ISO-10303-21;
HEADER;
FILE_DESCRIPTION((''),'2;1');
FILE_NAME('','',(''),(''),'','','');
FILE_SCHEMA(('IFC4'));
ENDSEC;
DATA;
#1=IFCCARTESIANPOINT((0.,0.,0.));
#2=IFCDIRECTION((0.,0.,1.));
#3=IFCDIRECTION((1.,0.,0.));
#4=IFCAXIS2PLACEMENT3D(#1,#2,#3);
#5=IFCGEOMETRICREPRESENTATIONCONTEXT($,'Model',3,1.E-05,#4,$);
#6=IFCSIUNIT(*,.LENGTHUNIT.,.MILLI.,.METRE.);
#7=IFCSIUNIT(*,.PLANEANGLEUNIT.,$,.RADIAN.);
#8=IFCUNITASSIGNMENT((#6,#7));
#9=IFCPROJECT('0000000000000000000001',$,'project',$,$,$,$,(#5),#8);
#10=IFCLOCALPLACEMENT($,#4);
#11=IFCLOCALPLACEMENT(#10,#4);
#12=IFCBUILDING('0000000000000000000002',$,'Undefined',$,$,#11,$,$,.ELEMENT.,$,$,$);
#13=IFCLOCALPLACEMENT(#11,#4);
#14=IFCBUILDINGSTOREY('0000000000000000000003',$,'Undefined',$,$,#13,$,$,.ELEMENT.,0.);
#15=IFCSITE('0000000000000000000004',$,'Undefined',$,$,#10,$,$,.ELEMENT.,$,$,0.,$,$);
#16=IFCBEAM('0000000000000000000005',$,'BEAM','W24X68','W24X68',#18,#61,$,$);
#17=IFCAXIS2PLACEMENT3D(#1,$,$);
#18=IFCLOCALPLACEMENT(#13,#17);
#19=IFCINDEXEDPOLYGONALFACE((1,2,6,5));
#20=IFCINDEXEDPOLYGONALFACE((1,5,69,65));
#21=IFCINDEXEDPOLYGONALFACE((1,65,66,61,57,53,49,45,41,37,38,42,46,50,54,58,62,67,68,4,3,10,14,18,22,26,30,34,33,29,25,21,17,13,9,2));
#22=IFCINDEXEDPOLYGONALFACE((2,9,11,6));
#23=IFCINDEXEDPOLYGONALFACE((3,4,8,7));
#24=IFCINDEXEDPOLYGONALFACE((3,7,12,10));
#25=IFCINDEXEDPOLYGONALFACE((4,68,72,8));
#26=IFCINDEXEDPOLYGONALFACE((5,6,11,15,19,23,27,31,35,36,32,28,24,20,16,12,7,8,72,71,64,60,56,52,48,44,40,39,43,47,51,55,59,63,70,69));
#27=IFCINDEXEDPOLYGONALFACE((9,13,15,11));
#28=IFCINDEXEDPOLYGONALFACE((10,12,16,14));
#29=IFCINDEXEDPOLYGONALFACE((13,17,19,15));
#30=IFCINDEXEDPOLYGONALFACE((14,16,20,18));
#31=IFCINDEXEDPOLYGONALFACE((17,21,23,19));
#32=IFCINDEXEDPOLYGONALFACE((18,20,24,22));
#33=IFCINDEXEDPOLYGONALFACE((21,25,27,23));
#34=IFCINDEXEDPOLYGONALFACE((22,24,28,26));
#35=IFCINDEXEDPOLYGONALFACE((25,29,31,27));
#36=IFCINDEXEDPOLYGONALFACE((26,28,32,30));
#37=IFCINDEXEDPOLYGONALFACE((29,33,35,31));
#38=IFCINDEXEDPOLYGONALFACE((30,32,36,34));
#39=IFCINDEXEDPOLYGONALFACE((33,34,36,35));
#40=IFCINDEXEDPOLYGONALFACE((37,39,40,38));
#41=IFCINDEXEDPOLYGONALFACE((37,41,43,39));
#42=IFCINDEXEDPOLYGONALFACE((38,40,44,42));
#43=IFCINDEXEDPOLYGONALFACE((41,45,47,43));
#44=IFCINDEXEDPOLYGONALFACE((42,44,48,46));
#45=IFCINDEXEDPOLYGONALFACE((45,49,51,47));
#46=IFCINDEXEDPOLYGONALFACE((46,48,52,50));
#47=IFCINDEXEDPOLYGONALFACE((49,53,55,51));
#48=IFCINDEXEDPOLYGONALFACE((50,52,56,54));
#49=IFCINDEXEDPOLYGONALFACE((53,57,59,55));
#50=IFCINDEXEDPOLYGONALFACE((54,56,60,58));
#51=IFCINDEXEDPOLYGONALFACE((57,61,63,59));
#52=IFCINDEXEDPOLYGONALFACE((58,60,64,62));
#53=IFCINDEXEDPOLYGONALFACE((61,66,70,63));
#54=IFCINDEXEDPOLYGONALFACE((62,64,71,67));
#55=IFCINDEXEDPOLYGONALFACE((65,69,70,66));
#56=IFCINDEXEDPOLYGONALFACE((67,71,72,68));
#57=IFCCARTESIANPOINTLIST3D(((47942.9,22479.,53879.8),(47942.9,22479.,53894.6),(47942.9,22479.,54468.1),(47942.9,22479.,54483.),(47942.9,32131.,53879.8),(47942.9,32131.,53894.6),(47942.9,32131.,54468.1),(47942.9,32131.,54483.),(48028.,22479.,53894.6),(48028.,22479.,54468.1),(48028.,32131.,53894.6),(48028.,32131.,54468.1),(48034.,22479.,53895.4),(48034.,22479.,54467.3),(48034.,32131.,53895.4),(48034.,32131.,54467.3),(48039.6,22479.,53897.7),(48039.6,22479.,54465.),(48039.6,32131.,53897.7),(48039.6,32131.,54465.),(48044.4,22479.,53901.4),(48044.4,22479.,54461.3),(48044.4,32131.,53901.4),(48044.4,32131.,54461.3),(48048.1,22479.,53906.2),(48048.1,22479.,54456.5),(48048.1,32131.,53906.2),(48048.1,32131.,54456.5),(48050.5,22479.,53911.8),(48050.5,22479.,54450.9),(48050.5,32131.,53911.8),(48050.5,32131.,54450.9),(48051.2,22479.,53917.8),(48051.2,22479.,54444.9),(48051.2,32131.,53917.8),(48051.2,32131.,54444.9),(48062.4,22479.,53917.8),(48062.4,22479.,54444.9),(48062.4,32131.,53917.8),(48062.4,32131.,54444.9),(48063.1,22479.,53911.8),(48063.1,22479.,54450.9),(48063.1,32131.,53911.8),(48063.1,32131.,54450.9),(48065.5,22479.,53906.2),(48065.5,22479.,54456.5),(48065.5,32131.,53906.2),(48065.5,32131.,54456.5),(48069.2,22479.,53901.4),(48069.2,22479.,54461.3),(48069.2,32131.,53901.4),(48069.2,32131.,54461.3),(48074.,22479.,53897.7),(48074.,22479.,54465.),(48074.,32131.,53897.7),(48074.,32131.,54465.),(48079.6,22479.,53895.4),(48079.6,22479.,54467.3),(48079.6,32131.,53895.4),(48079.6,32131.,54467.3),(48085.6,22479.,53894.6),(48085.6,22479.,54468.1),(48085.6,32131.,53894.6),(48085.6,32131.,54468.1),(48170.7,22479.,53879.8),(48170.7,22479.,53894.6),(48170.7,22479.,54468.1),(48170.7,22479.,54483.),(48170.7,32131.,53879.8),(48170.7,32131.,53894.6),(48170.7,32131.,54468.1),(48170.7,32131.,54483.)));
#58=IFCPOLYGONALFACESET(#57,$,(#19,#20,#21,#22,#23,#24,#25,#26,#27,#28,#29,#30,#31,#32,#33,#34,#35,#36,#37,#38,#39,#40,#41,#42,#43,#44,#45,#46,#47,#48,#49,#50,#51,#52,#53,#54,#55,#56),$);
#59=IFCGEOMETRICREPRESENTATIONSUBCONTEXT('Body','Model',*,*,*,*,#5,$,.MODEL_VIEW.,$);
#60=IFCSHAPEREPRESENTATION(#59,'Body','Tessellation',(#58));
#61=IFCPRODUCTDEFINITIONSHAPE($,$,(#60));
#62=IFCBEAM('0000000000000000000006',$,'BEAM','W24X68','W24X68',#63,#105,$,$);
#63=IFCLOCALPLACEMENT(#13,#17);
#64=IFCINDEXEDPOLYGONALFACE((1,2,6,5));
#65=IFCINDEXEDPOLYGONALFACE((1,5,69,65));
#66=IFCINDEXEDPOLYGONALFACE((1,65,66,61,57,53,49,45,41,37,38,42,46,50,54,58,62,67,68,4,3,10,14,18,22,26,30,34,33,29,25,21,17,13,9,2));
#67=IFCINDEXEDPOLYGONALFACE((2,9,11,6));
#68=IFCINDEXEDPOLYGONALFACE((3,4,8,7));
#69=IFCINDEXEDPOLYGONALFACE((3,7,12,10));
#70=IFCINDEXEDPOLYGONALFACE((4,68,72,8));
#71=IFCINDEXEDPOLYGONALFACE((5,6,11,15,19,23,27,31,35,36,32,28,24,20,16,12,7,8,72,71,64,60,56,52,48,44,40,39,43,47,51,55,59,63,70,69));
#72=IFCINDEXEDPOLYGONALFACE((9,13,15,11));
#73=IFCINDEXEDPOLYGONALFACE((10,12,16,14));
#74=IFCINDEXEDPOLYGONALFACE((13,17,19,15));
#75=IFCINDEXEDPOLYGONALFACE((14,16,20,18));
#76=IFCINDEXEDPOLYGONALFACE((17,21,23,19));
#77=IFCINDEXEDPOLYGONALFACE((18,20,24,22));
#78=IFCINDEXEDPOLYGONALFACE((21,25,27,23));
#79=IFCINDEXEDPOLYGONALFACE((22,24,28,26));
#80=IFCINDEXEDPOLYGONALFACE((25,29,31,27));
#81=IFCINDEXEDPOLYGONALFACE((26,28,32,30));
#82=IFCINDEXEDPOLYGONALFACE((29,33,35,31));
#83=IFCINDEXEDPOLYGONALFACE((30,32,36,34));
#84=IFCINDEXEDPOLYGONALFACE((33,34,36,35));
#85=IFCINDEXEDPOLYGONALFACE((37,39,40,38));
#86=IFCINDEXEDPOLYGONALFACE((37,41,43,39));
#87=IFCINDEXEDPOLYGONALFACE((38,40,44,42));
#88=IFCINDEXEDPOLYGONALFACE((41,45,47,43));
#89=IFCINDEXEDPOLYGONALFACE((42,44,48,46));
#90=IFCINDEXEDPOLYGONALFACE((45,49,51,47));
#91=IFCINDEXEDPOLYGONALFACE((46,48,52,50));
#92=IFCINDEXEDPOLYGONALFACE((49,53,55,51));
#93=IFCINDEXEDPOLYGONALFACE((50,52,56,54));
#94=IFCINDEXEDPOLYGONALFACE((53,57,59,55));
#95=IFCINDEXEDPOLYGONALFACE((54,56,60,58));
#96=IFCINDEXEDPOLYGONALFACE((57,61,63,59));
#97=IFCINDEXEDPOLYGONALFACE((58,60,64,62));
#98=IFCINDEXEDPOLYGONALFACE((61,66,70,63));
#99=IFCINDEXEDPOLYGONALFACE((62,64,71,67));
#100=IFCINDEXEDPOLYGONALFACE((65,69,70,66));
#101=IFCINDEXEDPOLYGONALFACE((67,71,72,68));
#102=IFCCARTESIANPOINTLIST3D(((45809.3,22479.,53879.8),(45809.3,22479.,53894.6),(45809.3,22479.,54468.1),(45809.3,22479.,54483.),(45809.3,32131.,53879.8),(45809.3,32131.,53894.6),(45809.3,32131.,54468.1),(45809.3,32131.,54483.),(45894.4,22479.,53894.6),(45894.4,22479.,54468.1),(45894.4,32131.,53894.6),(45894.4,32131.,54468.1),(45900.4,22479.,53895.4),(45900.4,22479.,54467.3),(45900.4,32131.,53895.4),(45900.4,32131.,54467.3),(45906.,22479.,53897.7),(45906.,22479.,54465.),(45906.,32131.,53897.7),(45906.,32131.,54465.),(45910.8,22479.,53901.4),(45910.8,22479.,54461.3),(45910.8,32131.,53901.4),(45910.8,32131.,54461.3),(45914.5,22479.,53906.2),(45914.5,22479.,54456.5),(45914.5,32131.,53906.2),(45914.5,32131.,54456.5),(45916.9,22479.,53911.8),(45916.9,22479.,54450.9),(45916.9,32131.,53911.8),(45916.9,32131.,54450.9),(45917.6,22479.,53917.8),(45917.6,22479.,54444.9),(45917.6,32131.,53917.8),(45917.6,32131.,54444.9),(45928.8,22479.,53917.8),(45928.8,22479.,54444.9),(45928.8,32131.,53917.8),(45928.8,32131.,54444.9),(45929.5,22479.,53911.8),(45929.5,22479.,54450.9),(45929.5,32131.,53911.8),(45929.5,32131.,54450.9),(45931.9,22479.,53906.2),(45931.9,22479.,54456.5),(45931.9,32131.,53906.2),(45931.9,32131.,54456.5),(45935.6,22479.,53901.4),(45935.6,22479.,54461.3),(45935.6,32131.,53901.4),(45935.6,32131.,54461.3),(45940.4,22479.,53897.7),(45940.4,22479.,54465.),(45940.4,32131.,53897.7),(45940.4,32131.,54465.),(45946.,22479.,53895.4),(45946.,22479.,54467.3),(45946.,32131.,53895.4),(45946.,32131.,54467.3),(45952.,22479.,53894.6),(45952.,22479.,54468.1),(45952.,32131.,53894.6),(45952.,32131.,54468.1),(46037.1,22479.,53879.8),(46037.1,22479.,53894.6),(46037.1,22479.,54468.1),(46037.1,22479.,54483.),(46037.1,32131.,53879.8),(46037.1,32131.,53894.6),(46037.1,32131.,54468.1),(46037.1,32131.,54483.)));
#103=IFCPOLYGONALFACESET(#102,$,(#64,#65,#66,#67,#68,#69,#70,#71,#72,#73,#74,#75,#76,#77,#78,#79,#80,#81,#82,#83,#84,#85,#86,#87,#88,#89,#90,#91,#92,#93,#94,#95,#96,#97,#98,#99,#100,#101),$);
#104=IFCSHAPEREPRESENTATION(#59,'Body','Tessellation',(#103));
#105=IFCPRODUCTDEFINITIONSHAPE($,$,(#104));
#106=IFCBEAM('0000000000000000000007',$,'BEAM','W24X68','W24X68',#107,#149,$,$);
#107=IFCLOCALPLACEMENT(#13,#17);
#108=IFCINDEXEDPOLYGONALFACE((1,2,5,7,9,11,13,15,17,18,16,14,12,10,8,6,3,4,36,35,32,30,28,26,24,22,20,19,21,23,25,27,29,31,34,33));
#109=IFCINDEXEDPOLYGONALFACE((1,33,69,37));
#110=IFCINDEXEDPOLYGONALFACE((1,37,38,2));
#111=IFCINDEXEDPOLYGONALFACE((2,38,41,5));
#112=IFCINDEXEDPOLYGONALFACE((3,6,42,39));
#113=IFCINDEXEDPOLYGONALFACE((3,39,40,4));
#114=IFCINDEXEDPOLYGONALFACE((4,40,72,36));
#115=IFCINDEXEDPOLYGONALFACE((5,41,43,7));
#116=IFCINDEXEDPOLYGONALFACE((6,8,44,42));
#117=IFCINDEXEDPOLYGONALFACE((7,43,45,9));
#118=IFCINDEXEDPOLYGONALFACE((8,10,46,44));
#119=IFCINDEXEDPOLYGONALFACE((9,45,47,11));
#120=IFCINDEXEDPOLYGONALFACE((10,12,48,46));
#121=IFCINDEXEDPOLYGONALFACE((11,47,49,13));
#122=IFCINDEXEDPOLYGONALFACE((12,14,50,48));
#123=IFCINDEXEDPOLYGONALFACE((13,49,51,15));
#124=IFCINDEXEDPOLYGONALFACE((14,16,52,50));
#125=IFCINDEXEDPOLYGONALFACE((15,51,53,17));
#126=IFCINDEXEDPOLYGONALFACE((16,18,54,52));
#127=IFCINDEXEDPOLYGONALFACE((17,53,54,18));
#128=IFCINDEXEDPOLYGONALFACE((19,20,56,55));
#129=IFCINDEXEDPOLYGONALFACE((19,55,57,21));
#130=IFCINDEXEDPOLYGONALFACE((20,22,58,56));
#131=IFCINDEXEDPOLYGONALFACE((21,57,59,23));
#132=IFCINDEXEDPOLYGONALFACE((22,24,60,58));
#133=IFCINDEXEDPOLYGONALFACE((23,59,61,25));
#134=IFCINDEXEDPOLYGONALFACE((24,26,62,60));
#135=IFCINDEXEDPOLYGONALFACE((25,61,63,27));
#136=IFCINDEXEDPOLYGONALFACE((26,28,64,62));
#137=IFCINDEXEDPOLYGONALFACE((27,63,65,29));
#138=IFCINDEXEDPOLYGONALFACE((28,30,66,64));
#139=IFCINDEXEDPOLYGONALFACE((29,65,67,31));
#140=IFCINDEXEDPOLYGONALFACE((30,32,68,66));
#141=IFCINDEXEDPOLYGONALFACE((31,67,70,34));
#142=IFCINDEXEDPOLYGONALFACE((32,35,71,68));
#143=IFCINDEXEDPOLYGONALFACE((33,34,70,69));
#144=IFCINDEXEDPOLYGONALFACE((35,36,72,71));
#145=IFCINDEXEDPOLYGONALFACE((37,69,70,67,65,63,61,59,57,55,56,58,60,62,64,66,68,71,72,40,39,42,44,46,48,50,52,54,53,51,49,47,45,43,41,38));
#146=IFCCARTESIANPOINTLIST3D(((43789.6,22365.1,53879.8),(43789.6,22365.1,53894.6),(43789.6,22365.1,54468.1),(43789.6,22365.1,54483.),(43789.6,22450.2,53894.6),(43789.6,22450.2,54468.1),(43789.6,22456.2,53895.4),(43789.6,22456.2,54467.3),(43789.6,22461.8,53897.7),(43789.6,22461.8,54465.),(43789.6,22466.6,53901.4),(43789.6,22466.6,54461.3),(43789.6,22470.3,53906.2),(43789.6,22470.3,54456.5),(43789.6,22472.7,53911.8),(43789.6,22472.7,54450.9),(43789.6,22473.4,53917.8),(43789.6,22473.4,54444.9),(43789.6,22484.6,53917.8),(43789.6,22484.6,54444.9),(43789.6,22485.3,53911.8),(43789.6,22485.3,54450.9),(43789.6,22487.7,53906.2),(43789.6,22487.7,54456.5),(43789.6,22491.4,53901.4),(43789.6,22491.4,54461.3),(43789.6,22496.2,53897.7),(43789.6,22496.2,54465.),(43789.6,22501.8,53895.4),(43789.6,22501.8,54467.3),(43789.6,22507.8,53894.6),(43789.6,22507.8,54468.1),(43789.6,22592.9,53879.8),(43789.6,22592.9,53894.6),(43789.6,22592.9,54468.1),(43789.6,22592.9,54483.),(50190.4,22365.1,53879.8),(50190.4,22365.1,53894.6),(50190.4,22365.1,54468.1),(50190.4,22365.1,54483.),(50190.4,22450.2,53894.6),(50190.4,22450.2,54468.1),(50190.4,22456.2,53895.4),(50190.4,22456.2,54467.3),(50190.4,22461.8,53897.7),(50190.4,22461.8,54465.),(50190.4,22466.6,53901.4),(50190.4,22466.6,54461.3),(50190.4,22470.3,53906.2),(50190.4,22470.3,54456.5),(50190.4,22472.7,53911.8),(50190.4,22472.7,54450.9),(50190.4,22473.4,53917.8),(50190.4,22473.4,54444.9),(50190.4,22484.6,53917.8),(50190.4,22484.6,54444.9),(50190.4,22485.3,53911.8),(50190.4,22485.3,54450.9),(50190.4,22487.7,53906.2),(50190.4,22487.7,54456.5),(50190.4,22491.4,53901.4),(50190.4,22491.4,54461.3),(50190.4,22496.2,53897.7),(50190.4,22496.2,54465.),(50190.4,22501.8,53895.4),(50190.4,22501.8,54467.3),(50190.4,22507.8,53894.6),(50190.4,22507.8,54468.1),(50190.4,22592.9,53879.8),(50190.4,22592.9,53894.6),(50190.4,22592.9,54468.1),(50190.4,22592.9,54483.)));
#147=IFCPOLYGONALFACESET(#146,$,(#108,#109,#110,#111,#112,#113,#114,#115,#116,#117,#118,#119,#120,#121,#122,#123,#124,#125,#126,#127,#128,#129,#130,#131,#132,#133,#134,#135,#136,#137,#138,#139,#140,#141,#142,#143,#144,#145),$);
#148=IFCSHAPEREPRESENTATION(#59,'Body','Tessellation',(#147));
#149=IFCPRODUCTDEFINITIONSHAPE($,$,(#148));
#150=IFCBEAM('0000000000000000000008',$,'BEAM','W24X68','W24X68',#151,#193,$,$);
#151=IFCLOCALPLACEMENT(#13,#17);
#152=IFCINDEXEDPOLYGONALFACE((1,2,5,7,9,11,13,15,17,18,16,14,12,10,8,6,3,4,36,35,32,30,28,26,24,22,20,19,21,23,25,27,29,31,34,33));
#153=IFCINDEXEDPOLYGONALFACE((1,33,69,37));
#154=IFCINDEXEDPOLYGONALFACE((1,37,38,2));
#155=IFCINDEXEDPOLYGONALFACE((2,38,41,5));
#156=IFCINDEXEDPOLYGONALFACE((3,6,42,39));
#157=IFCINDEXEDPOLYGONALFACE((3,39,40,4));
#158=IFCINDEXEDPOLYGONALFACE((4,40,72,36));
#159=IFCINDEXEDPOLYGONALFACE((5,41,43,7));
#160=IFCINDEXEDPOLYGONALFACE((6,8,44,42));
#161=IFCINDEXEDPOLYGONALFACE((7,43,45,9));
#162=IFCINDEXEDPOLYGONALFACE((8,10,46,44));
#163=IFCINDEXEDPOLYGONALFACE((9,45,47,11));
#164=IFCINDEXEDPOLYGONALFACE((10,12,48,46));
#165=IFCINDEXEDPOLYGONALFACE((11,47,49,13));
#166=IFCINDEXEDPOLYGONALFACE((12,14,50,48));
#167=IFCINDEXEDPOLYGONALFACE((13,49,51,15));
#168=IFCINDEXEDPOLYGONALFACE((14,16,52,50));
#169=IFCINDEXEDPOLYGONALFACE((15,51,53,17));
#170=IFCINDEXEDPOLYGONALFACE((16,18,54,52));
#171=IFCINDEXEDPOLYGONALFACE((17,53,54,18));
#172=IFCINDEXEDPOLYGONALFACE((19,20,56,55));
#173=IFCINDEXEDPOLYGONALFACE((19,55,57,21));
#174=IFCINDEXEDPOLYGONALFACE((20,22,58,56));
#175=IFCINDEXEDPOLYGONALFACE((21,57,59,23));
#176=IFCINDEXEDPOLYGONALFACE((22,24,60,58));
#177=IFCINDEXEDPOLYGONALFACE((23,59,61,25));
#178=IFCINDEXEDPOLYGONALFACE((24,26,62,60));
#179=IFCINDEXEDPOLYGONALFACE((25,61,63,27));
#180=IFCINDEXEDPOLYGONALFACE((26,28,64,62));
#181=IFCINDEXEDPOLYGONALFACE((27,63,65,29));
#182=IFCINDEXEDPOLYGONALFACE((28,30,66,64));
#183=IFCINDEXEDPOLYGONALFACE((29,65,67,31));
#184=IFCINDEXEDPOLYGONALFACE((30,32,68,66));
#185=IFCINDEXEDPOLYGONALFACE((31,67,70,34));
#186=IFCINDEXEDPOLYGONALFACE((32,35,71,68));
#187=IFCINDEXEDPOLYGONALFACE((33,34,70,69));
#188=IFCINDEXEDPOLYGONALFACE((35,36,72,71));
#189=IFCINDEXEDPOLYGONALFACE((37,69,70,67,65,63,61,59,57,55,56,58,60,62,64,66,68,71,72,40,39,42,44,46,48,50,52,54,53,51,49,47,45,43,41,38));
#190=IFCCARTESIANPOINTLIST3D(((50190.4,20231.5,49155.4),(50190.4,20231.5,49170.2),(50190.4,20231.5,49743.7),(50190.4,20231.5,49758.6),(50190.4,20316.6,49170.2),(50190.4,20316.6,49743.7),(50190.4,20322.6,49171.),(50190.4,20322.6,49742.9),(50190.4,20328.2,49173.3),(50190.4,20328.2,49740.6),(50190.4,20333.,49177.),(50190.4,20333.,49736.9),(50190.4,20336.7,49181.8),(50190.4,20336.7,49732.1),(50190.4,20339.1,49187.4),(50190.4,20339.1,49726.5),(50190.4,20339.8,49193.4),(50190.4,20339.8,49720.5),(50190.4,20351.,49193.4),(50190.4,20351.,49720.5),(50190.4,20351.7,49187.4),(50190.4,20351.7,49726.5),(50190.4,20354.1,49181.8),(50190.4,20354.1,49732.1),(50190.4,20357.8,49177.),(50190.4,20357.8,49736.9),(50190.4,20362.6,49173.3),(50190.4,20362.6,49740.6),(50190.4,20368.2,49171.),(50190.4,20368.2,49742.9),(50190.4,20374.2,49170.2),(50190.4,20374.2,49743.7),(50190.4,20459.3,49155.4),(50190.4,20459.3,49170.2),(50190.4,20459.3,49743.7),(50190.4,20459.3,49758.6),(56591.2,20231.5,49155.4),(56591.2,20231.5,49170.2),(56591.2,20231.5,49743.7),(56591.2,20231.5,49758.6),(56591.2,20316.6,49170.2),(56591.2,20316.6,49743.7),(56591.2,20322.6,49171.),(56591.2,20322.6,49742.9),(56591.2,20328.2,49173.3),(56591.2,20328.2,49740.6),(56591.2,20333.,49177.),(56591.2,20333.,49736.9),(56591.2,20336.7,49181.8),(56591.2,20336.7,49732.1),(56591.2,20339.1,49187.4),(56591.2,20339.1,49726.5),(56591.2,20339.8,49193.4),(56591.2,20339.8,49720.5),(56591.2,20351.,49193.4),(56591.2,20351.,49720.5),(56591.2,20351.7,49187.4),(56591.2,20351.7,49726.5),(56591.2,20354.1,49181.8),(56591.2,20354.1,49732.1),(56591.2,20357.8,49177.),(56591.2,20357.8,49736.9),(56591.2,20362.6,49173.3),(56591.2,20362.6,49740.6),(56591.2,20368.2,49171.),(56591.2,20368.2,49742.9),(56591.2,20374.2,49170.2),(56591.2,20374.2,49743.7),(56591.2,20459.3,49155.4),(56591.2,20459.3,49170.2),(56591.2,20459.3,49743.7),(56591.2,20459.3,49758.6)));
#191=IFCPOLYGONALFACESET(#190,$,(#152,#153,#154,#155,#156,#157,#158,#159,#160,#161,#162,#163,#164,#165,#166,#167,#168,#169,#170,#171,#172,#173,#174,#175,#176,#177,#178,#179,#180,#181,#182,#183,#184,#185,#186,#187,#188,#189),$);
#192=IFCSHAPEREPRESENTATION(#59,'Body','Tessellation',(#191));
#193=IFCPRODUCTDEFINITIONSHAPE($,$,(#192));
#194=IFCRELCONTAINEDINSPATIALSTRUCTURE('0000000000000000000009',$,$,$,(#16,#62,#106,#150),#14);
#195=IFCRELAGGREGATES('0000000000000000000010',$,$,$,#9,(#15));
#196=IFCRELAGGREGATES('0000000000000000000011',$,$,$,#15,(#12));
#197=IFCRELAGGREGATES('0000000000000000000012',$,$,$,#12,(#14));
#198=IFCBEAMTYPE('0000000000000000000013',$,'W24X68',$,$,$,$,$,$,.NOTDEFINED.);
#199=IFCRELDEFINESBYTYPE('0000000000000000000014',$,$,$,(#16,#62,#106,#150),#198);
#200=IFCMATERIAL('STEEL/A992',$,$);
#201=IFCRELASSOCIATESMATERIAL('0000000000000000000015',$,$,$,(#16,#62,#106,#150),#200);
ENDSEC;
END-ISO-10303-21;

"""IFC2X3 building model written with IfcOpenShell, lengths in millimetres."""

from ifc_helpers import new_model, si_unit, frame, origin_with_axes, origin_2d_with_axis, place, context, subcontext, project, spatial, i_section, extrude, material, type_object, element, save


model = new_model("IFC2X3")

# Units and contexts
model_context = context("Model", 3, precision=1e-05, world=origin_with_axes())
body_context = subcontext(model_context, "Body", "Model", "MODEL_VIEW")
ifc_project = project(units=[si_unit("LENGTHUNIT", "METRE", prefix="MILLI"), si_unit("PLANEANGLEUNIT", "RADIAN")], contexts=[model_context])

# Site, building, storey
site_placement = place(None, origin_with_axes())
site = spatial("IfcSite", under=ifc_project, at=site_placement, Name="Undefined", CompositionType="ELEMENT", RefElevation=0.0)
building_placement = place(site_placement, origin_with_axes())
building = spatial("IfcBuilding", under=site, at=building_placement, Name="Undefined", CompositionType="ELEMENT")
storey_placement = place(building_placement, origin_with_axes())
storey = spatial("IfcBuildingStorey", under=building, at=storey_placement, Name="Undefined", CompositionType="ELEMENT", Elevation=0.0)

# Shared definitions
ifc_material = material(Name="STEEL/A992")

# Beams
beam_type = type_object("IfcBeamType", Name="W24X68", PredefinedType="NOTDEFINED")
for number, where, z_axis, x_axis, name in (
    (1, (48056.8, 22479.0, 54181.4), (0.0, 0.0, 1.0), (0.0, 1.0, 0.0), "BEAM"),
    (2, (45923.2, 22479.0, 54181.4), (0.0, 0.0, 1.0), (0.0, 1.0, 0.0), "BEAM"),
):
    element("IfcBeam", number, at=place(storey_placement, frame(where, z_axis=z_axis, x_axis=x_axis)), inside=storey, type_object=beam_type, material=ifc_material, Name=name, Description="W24X68", ObjectType="W24X68", context=body_context, shape_type="SweptSolid", body=[
        extrude(i_section(OverallWidth=227.8, OverallDepth=603.2, WebThickness=11.1, FlangeThickness=14.9, FilletRadius=23.2, at=origin_2d_with_axis()), frame((9652.0, 0.0, 0.0), z_axis=(-1.0, 0.0, 0.0), x_axis=(0.0, -1.0, 0.0)), (0.0, 0.0, 1.0), 9652.0),
    ])
beam_1_placement = place(storey_placement, frame((43789.6, 22479.0, 54181.4), z_axis=(0.0, 0.0, 1.0), x_axis=(1.0, 0.0, 0.0)))
element("IfcBeam", 3, at=beam_1_placement, inside=storey, type_object=beam_type, material=ifc_material, Name="BEAM", Description="W24X68", ObjectType="W24X68", context=body_context, shape_type="SweptSolid", body=[
    extrude(i_section(OverallWidth=227.8, OverallDepth=603.2, WebThickness=11.1, FlangeThickness=14.9, FilletRadius=23.2, at=origin_2d_with_axis()), frame((6400.8, 0.0, 0.0), z_axis=(-1.0, 0.0, 0.0), x_axis=(0.0, -1.0, 0.0)), (0.0, 0.0, 1.0), 6400.8),
])
beam_2_placement = place(storey_placement, frame((50190.4, 20345.4, 49457.0), z_axis=(0.0, 0.0, 1.0), x_axis=(1.0, 0.0, 0.0)))
element("IfcBeam", 4, at=beam_2_placement, inside=storey, type_object=beam_type, material=ifc_material, Name="BEAM", Description="W24X68", ObjectType="W24X68", context=body_context, shape_type="SweptSolid", body=[
    extrude(i_section(OverallWidth=227.8, OverallDepth=603.2, WebThickness=11.1, FlangeThickness=14.9, FilletRadius=23.2, at=origin_2d_with_axis()), frame((6400.8, 0.0, 0.0), z_axis=(-1.0, 0.0, 0.0), x_axis=(0.0, -1.0, 0.0)), (0.0, 0.0, 1.0), 6400.8),
])

save(model, "model.ifc")
